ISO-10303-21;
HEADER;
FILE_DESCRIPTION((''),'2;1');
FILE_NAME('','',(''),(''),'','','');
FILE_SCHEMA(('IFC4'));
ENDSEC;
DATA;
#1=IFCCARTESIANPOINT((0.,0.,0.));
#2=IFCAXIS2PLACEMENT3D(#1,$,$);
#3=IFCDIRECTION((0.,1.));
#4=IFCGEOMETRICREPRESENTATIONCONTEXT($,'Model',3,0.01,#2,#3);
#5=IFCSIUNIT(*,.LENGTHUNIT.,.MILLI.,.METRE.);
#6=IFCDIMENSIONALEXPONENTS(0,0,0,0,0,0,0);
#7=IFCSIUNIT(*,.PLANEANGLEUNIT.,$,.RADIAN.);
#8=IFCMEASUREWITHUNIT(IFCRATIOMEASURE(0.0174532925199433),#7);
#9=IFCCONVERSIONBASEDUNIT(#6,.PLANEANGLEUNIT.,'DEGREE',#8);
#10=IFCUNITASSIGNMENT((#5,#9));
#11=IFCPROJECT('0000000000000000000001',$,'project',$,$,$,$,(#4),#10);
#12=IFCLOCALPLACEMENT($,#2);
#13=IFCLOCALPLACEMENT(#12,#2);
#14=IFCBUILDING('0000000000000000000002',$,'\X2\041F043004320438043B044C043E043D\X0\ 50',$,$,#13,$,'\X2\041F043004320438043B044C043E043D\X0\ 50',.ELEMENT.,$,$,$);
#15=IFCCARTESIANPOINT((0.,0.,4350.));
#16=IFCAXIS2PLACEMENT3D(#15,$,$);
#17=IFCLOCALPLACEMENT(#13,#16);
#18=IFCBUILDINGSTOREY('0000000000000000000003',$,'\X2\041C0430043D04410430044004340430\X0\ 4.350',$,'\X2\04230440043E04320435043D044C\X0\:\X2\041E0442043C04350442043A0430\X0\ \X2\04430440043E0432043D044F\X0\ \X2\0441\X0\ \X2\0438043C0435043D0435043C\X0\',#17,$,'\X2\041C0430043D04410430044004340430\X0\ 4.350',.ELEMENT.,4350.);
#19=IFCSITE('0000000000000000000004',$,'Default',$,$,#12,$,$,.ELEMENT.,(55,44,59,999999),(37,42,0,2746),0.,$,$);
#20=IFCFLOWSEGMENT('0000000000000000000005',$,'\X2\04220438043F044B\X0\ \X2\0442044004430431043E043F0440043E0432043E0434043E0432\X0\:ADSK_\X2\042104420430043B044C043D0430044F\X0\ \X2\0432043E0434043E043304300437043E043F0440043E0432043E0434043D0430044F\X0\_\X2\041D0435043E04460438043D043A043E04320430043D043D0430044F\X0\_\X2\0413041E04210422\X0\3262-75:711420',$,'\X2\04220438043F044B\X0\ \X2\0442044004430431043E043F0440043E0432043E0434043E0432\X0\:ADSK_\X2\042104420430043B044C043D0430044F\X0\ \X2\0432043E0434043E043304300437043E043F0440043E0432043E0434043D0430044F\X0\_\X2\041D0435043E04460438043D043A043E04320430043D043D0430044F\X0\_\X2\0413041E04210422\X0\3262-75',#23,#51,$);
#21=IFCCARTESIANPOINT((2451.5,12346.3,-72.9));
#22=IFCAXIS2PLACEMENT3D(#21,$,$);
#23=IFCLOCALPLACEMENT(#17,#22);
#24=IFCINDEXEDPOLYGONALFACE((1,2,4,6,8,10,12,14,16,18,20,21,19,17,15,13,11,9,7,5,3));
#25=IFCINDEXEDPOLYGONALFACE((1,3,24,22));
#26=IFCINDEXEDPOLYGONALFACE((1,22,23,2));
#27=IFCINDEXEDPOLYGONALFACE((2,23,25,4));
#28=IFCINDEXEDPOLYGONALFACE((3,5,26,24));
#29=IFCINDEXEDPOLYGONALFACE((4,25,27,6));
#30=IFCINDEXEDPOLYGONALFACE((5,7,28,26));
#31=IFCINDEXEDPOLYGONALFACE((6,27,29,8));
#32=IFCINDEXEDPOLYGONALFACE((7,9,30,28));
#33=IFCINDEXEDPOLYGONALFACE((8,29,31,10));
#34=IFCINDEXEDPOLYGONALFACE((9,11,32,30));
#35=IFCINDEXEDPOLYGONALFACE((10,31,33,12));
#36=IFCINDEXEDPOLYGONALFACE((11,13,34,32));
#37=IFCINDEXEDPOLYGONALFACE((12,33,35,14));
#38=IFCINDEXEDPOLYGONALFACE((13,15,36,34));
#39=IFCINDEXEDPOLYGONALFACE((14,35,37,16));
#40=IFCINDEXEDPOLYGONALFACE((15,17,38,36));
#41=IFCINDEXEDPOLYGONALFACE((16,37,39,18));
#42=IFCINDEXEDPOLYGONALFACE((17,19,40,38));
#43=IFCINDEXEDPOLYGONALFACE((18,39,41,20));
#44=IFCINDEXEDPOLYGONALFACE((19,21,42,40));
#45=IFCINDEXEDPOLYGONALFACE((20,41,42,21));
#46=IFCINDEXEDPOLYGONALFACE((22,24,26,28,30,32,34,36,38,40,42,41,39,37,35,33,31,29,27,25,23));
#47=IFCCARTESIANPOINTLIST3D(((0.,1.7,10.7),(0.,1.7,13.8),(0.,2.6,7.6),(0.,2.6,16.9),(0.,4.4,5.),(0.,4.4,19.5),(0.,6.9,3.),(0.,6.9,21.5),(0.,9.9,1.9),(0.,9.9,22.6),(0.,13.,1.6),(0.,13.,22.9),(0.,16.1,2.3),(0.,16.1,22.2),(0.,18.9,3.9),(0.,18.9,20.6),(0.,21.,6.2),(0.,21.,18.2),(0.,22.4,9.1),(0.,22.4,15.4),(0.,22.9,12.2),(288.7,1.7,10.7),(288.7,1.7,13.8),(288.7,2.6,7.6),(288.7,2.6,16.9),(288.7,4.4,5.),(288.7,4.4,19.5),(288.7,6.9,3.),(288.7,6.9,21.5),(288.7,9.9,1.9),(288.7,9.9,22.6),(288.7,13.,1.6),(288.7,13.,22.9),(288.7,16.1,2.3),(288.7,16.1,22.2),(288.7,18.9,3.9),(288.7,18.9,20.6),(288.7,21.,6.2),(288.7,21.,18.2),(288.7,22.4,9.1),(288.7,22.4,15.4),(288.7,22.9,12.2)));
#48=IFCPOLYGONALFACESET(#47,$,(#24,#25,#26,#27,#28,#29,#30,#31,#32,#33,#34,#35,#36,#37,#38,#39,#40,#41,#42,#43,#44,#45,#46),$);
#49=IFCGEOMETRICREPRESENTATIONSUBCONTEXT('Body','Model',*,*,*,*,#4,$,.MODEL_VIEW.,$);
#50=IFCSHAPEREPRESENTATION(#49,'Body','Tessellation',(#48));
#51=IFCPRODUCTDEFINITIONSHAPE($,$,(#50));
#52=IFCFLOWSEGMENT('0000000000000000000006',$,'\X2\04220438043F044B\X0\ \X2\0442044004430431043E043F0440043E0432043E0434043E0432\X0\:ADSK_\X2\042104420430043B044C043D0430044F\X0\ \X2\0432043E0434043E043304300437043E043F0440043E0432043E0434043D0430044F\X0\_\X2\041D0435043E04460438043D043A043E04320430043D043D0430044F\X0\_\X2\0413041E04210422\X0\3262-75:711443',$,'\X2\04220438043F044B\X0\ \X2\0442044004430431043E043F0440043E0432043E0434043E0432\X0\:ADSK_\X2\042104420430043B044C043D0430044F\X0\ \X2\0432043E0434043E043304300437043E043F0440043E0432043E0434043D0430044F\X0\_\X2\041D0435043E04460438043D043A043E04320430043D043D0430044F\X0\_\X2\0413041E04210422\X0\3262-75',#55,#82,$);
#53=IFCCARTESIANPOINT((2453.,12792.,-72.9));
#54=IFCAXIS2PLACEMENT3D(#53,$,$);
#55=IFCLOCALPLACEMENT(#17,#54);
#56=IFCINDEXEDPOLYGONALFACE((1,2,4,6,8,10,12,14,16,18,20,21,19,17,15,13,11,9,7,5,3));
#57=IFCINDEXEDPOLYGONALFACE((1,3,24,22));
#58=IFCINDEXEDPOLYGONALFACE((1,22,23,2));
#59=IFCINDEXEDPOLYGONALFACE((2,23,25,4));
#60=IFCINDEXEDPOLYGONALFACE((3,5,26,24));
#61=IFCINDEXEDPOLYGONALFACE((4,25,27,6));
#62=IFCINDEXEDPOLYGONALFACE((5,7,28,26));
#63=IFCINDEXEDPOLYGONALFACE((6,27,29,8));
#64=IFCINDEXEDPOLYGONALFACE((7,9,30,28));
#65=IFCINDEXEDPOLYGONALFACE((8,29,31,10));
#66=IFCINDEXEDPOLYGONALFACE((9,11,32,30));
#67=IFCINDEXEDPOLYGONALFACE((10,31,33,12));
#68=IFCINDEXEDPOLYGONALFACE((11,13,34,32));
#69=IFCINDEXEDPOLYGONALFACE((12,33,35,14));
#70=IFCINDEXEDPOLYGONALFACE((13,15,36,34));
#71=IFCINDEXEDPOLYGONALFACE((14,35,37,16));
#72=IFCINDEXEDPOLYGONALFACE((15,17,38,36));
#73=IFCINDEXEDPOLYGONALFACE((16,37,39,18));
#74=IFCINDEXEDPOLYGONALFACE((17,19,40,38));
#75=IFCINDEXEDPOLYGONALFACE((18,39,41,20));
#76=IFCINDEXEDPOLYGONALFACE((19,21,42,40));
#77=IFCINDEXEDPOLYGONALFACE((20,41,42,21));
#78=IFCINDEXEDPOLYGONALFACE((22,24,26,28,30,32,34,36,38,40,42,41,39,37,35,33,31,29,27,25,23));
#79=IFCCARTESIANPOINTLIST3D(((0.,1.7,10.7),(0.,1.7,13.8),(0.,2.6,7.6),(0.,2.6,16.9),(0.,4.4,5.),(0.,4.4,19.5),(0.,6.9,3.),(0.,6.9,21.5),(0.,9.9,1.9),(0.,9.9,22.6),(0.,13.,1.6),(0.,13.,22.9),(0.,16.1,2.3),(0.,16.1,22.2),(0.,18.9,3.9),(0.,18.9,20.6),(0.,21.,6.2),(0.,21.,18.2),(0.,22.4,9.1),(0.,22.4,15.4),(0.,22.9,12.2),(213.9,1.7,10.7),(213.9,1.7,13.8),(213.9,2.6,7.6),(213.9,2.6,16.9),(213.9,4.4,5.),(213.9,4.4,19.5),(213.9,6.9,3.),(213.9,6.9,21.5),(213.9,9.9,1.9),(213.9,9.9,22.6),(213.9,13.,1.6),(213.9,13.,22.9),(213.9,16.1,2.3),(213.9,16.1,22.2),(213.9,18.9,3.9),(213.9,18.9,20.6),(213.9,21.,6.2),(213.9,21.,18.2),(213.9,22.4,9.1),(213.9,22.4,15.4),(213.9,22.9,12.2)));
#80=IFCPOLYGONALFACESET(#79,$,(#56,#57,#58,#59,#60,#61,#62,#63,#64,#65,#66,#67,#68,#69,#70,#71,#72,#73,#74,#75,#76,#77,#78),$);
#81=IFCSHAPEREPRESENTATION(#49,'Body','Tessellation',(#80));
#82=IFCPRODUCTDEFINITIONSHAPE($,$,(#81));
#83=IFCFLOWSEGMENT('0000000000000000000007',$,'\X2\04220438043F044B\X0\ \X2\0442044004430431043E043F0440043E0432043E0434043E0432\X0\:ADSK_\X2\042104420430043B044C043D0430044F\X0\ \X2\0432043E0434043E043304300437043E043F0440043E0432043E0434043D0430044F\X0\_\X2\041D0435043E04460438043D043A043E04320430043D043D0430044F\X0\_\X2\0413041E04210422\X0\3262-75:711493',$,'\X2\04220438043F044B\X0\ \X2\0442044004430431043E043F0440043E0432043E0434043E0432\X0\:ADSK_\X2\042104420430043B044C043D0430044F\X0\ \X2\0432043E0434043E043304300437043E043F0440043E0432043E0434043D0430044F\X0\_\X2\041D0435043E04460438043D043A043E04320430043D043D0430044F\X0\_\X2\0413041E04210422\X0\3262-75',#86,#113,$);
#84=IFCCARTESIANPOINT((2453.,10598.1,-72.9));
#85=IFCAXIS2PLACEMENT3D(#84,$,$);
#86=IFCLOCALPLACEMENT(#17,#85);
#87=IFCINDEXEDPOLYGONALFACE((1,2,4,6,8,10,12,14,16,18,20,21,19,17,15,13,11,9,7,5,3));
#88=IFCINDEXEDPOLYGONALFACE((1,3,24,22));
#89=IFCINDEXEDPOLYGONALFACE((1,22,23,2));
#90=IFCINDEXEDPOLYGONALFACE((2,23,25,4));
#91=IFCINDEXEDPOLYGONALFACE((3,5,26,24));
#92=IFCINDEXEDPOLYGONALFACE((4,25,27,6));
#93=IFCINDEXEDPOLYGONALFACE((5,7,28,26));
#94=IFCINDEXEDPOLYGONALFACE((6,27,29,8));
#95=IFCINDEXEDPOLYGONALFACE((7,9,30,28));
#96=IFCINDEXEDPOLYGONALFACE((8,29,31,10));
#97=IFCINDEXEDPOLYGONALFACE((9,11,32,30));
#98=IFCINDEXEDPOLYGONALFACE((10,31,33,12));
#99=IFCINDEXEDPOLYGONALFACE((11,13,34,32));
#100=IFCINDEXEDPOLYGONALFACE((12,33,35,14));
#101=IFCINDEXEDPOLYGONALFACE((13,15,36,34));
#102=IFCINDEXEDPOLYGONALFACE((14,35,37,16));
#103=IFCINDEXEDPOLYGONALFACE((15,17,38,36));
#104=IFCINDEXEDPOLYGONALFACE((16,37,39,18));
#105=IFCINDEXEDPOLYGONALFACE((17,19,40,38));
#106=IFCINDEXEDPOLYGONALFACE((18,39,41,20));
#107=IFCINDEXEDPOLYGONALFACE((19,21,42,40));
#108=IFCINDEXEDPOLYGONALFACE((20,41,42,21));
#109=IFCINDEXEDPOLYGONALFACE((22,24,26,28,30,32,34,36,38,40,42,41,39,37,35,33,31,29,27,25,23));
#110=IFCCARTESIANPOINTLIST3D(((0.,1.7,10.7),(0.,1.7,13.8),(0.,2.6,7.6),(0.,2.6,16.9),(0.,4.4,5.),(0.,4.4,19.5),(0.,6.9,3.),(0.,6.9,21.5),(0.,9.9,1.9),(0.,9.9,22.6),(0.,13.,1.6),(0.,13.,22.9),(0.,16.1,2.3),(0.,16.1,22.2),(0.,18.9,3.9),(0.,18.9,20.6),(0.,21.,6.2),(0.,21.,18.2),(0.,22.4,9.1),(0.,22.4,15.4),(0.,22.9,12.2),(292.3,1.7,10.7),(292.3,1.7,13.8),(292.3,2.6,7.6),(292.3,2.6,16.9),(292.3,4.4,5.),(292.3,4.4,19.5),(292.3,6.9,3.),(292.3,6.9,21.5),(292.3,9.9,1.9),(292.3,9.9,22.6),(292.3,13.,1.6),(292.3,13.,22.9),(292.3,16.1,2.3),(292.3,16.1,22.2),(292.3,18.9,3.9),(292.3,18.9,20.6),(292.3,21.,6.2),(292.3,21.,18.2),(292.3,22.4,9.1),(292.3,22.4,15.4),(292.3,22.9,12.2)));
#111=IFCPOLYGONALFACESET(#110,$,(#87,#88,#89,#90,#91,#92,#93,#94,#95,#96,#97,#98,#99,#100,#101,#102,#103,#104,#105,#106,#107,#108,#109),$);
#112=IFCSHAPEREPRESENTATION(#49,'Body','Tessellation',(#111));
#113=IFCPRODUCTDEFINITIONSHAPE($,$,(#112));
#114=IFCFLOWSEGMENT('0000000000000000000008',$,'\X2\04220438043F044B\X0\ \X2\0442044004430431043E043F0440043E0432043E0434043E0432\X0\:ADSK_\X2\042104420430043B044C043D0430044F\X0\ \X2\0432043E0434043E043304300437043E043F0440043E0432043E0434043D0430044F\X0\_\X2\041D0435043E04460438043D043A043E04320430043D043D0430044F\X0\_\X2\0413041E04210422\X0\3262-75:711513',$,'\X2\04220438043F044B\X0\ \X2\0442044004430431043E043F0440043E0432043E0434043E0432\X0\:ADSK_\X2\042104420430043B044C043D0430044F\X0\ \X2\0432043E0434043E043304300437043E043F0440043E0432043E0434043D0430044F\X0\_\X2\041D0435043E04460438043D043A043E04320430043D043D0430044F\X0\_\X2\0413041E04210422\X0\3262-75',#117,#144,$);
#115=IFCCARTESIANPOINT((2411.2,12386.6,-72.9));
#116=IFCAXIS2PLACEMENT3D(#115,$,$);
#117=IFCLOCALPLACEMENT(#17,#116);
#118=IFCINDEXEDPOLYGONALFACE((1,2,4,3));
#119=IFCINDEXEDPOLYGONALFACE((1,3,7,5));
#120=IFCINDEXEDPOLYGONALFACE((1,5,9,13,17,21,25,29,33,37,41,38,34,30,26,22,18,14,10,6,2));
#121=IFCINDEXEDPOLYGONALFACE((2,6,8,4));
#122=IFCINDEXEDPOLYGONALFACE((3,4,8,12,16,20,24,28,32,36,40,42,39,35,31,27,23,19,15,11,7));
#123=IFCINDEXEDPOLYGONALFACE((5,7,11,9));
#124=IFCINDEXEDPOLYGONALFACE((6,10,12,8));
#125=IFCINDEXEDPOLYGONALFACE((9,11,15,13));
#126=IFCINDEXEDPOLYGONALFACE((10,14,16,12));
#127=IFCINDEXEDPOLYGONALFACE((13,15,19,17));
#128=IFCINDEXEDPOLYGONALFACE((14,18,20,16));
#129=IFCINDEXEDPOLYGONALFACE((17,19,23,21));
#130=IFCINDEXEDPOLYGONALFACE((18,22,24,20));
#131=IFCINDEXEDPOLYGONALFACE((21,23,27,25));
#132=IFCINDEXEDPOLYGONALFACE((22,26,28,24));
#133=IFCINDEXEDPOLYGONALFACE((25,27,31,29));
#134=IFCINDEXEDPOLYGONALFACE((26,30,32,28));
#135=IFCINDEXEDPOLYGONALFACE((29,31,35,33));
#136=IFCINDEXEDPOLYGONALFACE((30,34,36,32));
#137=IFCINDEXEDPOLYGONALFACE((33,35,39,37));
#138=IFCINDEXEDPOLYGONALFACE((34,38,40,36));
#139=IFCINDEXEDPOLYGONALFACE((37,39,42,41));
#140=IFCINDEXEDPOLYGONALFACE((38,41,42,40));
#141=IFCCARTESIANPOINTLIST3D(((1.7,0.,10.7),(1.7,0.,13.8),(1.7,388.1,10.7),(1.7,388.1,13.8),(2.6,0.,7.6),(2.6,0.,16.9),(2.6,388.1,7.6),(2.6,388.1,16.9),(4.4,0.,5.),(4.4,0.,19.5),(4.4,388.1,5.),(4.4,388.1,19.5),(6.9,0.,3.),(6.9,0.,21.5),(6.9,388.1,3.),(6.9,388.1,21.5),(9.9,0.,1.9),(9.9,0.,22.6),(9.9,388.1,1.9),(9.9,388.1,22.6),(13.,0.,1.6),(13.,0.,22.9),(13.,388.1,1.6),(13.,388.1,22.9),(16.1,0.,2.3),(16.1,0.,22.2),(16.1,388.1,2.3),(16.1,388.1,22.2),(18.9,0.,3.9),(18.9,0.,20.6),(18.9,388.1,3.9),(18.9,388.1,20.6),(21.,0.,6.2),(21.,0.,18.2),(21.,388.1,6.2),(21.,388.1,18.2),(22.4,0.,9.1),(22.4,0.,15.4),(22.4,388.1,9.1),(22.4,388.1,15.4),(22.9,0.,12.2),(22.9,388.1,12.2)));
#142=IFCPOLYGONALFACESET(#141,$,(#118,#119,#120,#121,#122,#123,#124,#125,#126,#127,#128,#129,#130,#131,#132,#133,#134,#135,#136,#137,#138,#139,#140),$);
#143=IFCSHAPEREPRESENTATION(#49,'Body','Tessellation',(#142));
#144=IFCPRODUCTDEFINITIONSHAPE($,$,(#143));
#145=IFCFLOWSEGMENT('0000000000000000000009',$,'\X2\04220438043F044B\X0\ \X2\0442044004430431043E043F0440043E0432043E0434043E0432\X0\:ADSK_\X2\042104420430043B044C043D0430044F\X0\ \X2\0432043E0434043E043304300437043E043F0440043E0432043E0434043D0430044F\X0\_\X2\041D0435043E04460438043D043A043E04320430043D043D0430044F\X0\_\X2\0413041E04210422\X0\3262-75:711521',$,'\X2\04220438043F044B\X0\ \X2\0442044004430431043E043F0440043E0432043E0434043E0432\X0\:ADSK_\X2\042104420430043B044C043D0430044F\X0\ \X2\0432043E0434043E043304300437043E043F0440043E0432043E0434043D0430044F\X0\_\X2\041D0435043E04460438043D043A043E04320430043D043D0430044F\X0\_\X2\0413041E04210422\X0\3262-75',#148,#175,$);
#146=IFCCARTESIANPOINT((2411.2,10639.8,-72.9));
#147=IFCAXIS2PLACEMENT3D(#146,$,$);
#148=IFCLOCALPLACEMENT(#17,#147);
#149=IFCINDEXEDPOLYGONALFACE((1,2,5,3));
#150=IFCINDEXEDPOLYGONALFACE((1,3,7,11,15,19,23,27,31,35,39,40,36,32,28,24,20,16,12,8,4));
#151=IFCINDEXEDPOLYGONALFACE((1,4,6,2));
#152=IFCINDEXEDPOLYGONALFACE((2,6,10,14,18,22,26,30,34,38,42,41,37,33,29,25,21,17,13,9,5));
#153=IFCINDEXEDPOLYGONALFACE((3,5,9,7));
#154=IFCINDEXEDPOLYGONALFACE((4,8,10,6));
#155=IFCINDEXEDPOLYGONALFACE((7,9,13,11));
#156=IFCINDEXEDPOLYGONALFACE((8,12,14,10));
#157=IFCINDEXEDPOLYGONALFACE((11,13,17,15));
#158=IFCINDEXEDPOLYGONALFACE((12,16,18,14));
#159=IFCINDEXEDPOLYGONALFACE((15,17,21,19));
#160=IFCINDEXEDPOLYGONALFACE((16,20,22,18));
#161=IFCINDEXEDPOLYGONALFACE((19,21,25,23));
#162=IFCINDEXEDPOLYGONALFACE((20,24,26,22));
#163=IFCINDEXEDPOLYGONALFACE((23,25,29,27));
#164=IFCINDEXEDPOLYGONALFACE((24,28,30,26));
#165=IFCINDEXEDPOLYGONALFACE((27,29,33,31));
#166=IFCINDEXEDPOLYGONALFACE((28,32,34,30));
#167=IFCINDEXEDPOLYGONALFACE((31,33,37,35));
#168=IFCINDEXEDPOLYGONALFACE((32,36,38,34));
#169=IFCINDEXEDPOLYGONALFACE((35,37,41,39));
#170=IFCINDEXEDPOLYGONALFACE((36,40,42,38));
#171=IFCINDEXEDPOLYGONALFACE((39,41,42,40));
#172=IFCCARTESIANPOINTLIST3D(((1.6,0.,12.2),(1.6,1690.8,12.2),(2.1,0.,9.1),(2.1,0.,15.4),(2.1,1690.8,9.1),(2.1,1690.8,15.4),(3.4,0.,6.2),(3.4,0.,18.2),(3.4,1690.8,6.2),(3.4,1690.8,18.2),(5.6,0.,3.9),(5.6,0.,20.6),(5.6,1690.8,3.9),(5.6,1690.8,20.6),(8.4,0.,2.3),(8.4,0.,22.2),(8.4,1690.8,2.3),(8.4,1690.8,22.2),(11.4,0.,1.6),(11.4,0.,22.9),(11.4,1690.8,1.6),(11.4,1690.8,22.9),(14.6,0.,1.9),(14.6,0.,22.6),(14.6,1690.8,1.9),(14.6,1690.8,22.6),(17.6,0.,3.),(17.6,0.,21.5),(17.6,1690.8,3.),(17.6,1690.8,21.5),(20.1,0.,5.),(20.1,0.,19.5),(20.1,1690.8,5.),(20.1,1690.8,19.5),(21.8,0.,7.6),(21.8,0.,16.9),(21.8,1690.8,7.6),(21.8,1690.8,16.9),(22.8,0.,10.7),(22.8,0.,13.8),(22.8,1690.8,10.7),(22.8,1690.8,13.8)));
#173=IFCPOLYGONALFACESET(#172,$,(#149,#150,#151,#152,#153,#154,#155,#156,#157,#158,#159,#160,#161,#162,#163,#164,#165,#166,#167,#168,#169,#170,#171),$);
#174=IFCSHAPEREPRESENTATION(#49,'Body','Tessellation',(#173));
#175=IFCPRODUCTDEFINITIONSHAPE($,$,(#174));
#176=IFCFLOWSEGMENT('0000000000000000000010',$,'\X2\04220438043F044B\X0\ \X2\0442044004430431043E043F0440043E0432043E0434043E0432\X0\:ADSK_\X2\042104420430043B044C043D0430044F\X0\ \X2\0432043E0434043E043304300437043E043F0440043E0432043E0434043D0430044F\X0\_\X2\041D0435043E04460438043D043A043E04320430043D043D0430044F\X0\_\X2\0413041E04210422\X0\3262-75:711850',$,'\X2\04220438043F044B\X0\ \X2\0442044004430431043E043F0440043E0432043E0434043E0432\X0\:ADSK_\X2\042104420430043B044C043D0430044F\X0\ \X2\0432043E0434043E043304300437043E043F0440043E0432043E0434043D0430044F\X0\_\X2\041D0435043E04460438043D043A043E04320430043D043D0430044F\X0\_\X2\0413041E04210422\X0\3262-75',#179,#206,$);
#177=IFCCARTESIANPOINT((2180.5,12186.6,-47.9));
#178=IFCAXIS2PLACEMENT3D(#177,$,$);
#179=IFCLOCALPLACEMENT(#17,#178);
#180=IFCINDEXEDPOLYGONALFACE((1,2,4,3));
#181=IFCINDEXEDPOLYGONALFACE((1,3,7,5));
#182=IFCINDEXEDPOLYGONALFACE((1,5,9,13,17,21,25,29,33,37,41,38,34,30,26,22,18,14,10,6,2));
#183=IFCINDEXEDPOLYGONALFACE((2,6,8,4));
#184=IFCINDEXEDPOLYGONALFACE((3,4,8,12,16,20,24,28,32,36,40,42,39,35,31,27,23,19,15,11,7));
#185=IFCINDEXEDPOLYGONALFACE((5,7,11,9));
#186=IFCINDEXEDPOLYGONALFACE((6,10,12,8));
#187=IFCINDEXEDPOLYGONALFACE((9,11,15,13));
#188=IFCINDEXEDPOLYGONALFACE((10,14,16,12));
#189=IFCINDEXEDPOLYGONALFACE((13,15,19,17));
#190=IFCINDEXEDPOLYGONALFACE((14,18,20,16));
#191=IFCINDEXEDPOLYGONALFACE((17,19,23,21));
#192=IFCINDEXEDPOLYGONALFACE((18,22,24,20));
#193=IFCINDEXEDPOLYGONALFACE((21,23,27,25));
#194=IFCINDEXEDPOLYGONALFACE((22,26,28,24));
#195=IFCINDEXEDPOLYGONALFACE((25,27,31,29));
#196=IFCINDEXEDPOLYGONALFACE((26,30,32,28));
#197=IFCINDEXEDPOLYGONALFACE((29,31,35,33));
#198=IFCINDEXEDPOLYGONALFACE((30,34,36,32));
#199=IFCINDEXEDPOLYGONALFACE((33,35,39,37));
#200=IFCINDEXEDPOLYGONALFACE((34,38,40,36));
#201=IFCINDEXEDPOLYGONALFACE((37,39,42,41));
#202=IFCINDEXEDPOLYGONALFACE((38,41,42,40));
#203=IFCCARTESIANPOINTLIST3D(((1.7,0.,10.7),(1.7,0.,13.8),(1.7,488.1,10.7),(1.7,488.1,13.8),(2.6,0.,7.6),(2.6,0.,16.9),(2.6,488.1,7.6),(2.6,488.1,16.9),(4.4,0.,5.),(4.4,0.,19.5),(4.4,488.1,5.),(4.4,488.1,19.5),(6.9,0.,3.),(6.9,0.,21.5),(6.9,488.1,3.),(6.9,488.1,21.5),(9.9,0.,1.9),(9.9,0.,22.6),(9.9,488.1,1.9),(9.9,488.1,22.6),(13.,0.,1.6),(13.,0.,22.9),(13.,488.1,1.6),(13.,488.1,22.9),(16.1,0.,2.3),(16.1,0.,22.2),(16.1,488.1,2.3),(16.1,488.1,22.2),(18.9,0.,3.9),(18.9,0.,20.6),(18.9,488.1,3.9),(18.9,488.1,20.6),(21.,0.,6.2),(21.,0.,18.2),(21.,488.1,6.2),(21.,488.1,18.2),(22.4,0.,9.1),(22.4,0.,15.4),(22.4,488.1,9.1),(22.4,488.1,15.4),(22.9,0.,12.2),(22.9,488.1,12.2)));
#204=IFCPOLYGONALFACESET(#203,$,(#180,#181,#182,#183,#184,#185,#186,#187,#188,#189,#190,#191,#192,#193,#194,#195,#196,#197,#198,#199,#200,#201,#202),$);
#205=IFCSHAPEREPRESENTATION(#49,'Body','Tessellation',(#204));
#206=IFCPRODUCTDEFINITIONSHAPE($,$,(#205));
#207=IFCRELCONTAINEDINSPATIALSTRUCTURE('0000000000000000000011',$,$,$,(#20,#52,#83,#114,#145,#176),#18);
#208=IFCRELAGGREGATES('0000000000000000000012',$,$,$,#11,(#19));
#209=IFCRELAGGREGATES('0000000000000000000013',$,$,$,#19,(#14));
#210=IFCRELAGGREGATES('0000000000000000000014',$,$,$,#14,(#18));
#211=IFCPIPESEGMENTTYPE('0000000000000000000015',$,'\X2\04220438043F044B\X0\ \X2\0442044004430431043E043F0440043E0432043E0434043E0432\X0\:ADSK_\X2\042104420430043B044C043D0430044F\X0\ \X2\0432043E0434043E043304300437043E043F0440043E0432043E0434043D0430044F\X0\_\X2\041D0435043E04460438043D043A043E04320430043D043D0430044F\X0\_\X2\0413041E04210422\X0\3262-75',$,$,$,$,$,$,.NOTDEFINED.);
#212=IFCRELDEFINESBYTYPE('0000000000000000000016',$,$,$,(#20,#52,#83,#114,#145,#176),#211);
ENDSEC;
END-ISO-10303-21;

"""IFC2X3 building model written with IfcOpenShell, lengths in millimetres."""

from ifc_helpers import new_model, entity, si_unit, converted_unit, direction, frame, origin, origin_2d_with_axis, place, context, subcontext, project, spatial, circle, extrude, type_object, element, save


model = new_model("IFC2X3")

# Units and contexts
model_context = context("Model", 3, precision=0.01, world=origin(), true_north=direction((0.0, 1.0)))
body_context = subcontext(model_context, "Body", "Model", "MODEL_VIEW")
ifc_project = project(units=[si_unit("LENGTHUNIT", "METRE", prefix="MILLI"), converted_unit("PLANEANGLEUNIT", "DEGREE", entity("IfcRatioMeasure", 0.0174532925199433), si_unit("PLANEANGLEUNIT", "RADIAN"), dimensions=[0, 0, 0, 0, 0, 0, 0])], contexts=[model_context])

# Site, building, storey
site_placement = place(None, origin())
site = spatial("IfcSite", under=ifc_project, at=site_placement, Name="Default", CompositionType="ELEMENT", RefLatitude=(55, 44, 59, 999999), RefLongitude=(37, 42, 0, 2746), RefElevation=0.0)
building_placement = place(site_placement, origin())
building = spatial("IfcBuilding", under=site, at=building_placement, Name="Павильон 50", LongName="Павильон 50", CompositionType="ELEMENT")
storey_placement = place(building_placement, frame((0.0, 0.0, 4350.0)))
storey = spatial("IfcBuildingStorey", under=building, at=storey_placement, Name="Мансарда 4.350", ObjectType="Уровень:Отметка уровня с именем", LongName="Мансарда 4.350", CompositionType="ELEMENT", Elevation=4350.0)

# Flow segments
pipe_segment_type = type_object("IfcPipeSegmentType", Name="Типы трубопроводов:ADSK_Стальная водогазопроводная_Неоцинкованная_ГОСТ3262-75", PredefinedType="NOTDEFINED")
flow_segment_1_placement = place(storey_placement, frame((2451.5, 12346.3, -72.9)))
element("IfcFlowSegment", 1, at=flow_segment_1_placement, inside=storey, type_object=pipe_segment_type, Name="Типы трубопроводов:ADSK_Стальная водогазопроводная_Неоцинкованная_ГОСТ3262-75:711420", ObjectType="Типы трубопроводов:ADSK_Стальная водогазопроводная_Неоцинкованная_ГОСТ3262-75", context=body_context, shape_type="SweptSolid", body=[
    extrude(circle(Radius=10.7, at=origin_2d_with_axis()), frame((0.0, 12.2, 12.2), z_axis=(1.0, 0.0, 0.0), x_axis=(0.0, 1.0, 0.0)), (0.0, 0.0, 1.0), 288.7),
])
flow_segment_2_placement = place(storey_placement, frame((2453.0, 12792.0, -72.9)))
element("IfcFlowSegment", 2, at=flow_segment_2_placement, inside=storey, type_object=pipe_segment_type, Name="Типы трубопроводов:ADSK_Стальная водогазопроводная_Неоцинкованная_ГОСТ3262-75:711443", ObjectType="Типы трубопроводов:ADSK_Стальная водогазопроводная_Неоцинкованная_ГОСТ3262-75", context=body_context, shape_type="SweptSolid", body=[
    extrude(circle(Radius=10.7, at=origin_2d_with_axis()), frame((0.0, 12.2, 12.2), z_axis=(1.0, 0.0, 0.0), x_axis=(0.0, 1.0, 0.0)), (0.0, 0.0, 1.0), 213.9),
])
flow_segment_3_placement = place(storey_placement, frame((2453.0, 10598.1, -72.9)))
element("IfcFlowSegment", 3, at=flow_segment_3_placement, inside=storey, type_object=pipe_segment_type, Name="Типы трубопроводов:ADSK_Стальная водогазопроводная_Неоцинкованная_ГОСТ3262-75:711493", ObjectType="Типы трубопроводов:ADSK_Стальная водогазопроводная_Неоцинкованная_ГОСТ3262-75", context=body_context, shape_type="SweptSolid", body=[
    extrude(circle(Radius=10.7, at=origin_2d_with_axis()), frame((0.0, 12.2, 12.2), z_axis=(1.0, 0.0, 0.0), x_axis=(0.0, 1.0, 0.0)), (0.0, 0.0, 1.0), 292.3),
])
flow_segment_4_placement = place(storey_placement, frame((2411.2, 12386.6, -72.9)))
element("IfcFlowSegment", 4, at=flow_segment_4_placement, inside=storey, type_object=pipe_segment_type, Name="Типы трубопроводов:ADSK_Стальная водогазопроводная_Неоцинкованная_ГОСТ3262-75:711513", ObjectType="Типы трубопроводов:ADSK_Стальная водогазопроводная_Неоцинкованная_ГОСТ3262-75", context=body_context, shape_type="SweptSolid", body=[
    extrude(circle(Radius=10.7, at=origin_2d_with_axis()), frame((12.2, 0.0, 12.2), z_axis=(0.0, 1.0, 0.0), x_axis=(1.0, 0.0, 0.0)), (0.0, 0.0, 1.0), 388.1),
])
flow_segment_5_placement = place(storey_placement, frame((2411.2, 10639.8, -72.9)))
element("IfcFlowSegment", 5, at=flow_segment_5_placement, inside=storey, type_object=pipe_segment_type, Name="Типы трубопроводов:ADSK_Стальная водогазопроводная_Неоцинкованная_ГОСТ3262-75:711521", ObjectType="Типы трубопроводов:ADSK_Стальная водогазопроводная_Неоцинкованная_ГОСТ3262-75", context=body_context, shape_type="SweptSolid", body=[
    extrude(circle(Radius=10.7, at=origin_2d_with_axis()), frame((12.2, 0.0, 12.2), z_axis=(0.0, 1.0, 0.0), x_axis=(-1.0, 0.0, 0.0)), (0.0, 0.0, 1.0), 1690.8),
])
flow_segment_6_placement = place(storey_placement, frame((2180.5, 12186.6, -47.9)))
element("IfcFlowSegment", 6, at=flow_segment_6_placement, inside=storey, type_object=pipe_segment_type, Name="Типы трубопроводов:ADSK_Стальная водогазопроводная_Неоцинкованная_ГОСТ3262-75:711850", ObjectType="Типы трубопроводов:ADSK_Стальная водогазопроводная_Неоцинкованная_ГОСТ3262-75", context=body_context, shape_type="SweptSolid", body=[
    extrude(circle(Radius=10.7, at=origin_2d_with_axis()), frame((12.2, 0.0, 12.2), z_axis=(0.0, 1.0, 0.0), x_axis=(1.0, 0.0, 0.0)), (0.0, 0.0, 1.0), 488.1),
])

save(model, "model.ifc")
